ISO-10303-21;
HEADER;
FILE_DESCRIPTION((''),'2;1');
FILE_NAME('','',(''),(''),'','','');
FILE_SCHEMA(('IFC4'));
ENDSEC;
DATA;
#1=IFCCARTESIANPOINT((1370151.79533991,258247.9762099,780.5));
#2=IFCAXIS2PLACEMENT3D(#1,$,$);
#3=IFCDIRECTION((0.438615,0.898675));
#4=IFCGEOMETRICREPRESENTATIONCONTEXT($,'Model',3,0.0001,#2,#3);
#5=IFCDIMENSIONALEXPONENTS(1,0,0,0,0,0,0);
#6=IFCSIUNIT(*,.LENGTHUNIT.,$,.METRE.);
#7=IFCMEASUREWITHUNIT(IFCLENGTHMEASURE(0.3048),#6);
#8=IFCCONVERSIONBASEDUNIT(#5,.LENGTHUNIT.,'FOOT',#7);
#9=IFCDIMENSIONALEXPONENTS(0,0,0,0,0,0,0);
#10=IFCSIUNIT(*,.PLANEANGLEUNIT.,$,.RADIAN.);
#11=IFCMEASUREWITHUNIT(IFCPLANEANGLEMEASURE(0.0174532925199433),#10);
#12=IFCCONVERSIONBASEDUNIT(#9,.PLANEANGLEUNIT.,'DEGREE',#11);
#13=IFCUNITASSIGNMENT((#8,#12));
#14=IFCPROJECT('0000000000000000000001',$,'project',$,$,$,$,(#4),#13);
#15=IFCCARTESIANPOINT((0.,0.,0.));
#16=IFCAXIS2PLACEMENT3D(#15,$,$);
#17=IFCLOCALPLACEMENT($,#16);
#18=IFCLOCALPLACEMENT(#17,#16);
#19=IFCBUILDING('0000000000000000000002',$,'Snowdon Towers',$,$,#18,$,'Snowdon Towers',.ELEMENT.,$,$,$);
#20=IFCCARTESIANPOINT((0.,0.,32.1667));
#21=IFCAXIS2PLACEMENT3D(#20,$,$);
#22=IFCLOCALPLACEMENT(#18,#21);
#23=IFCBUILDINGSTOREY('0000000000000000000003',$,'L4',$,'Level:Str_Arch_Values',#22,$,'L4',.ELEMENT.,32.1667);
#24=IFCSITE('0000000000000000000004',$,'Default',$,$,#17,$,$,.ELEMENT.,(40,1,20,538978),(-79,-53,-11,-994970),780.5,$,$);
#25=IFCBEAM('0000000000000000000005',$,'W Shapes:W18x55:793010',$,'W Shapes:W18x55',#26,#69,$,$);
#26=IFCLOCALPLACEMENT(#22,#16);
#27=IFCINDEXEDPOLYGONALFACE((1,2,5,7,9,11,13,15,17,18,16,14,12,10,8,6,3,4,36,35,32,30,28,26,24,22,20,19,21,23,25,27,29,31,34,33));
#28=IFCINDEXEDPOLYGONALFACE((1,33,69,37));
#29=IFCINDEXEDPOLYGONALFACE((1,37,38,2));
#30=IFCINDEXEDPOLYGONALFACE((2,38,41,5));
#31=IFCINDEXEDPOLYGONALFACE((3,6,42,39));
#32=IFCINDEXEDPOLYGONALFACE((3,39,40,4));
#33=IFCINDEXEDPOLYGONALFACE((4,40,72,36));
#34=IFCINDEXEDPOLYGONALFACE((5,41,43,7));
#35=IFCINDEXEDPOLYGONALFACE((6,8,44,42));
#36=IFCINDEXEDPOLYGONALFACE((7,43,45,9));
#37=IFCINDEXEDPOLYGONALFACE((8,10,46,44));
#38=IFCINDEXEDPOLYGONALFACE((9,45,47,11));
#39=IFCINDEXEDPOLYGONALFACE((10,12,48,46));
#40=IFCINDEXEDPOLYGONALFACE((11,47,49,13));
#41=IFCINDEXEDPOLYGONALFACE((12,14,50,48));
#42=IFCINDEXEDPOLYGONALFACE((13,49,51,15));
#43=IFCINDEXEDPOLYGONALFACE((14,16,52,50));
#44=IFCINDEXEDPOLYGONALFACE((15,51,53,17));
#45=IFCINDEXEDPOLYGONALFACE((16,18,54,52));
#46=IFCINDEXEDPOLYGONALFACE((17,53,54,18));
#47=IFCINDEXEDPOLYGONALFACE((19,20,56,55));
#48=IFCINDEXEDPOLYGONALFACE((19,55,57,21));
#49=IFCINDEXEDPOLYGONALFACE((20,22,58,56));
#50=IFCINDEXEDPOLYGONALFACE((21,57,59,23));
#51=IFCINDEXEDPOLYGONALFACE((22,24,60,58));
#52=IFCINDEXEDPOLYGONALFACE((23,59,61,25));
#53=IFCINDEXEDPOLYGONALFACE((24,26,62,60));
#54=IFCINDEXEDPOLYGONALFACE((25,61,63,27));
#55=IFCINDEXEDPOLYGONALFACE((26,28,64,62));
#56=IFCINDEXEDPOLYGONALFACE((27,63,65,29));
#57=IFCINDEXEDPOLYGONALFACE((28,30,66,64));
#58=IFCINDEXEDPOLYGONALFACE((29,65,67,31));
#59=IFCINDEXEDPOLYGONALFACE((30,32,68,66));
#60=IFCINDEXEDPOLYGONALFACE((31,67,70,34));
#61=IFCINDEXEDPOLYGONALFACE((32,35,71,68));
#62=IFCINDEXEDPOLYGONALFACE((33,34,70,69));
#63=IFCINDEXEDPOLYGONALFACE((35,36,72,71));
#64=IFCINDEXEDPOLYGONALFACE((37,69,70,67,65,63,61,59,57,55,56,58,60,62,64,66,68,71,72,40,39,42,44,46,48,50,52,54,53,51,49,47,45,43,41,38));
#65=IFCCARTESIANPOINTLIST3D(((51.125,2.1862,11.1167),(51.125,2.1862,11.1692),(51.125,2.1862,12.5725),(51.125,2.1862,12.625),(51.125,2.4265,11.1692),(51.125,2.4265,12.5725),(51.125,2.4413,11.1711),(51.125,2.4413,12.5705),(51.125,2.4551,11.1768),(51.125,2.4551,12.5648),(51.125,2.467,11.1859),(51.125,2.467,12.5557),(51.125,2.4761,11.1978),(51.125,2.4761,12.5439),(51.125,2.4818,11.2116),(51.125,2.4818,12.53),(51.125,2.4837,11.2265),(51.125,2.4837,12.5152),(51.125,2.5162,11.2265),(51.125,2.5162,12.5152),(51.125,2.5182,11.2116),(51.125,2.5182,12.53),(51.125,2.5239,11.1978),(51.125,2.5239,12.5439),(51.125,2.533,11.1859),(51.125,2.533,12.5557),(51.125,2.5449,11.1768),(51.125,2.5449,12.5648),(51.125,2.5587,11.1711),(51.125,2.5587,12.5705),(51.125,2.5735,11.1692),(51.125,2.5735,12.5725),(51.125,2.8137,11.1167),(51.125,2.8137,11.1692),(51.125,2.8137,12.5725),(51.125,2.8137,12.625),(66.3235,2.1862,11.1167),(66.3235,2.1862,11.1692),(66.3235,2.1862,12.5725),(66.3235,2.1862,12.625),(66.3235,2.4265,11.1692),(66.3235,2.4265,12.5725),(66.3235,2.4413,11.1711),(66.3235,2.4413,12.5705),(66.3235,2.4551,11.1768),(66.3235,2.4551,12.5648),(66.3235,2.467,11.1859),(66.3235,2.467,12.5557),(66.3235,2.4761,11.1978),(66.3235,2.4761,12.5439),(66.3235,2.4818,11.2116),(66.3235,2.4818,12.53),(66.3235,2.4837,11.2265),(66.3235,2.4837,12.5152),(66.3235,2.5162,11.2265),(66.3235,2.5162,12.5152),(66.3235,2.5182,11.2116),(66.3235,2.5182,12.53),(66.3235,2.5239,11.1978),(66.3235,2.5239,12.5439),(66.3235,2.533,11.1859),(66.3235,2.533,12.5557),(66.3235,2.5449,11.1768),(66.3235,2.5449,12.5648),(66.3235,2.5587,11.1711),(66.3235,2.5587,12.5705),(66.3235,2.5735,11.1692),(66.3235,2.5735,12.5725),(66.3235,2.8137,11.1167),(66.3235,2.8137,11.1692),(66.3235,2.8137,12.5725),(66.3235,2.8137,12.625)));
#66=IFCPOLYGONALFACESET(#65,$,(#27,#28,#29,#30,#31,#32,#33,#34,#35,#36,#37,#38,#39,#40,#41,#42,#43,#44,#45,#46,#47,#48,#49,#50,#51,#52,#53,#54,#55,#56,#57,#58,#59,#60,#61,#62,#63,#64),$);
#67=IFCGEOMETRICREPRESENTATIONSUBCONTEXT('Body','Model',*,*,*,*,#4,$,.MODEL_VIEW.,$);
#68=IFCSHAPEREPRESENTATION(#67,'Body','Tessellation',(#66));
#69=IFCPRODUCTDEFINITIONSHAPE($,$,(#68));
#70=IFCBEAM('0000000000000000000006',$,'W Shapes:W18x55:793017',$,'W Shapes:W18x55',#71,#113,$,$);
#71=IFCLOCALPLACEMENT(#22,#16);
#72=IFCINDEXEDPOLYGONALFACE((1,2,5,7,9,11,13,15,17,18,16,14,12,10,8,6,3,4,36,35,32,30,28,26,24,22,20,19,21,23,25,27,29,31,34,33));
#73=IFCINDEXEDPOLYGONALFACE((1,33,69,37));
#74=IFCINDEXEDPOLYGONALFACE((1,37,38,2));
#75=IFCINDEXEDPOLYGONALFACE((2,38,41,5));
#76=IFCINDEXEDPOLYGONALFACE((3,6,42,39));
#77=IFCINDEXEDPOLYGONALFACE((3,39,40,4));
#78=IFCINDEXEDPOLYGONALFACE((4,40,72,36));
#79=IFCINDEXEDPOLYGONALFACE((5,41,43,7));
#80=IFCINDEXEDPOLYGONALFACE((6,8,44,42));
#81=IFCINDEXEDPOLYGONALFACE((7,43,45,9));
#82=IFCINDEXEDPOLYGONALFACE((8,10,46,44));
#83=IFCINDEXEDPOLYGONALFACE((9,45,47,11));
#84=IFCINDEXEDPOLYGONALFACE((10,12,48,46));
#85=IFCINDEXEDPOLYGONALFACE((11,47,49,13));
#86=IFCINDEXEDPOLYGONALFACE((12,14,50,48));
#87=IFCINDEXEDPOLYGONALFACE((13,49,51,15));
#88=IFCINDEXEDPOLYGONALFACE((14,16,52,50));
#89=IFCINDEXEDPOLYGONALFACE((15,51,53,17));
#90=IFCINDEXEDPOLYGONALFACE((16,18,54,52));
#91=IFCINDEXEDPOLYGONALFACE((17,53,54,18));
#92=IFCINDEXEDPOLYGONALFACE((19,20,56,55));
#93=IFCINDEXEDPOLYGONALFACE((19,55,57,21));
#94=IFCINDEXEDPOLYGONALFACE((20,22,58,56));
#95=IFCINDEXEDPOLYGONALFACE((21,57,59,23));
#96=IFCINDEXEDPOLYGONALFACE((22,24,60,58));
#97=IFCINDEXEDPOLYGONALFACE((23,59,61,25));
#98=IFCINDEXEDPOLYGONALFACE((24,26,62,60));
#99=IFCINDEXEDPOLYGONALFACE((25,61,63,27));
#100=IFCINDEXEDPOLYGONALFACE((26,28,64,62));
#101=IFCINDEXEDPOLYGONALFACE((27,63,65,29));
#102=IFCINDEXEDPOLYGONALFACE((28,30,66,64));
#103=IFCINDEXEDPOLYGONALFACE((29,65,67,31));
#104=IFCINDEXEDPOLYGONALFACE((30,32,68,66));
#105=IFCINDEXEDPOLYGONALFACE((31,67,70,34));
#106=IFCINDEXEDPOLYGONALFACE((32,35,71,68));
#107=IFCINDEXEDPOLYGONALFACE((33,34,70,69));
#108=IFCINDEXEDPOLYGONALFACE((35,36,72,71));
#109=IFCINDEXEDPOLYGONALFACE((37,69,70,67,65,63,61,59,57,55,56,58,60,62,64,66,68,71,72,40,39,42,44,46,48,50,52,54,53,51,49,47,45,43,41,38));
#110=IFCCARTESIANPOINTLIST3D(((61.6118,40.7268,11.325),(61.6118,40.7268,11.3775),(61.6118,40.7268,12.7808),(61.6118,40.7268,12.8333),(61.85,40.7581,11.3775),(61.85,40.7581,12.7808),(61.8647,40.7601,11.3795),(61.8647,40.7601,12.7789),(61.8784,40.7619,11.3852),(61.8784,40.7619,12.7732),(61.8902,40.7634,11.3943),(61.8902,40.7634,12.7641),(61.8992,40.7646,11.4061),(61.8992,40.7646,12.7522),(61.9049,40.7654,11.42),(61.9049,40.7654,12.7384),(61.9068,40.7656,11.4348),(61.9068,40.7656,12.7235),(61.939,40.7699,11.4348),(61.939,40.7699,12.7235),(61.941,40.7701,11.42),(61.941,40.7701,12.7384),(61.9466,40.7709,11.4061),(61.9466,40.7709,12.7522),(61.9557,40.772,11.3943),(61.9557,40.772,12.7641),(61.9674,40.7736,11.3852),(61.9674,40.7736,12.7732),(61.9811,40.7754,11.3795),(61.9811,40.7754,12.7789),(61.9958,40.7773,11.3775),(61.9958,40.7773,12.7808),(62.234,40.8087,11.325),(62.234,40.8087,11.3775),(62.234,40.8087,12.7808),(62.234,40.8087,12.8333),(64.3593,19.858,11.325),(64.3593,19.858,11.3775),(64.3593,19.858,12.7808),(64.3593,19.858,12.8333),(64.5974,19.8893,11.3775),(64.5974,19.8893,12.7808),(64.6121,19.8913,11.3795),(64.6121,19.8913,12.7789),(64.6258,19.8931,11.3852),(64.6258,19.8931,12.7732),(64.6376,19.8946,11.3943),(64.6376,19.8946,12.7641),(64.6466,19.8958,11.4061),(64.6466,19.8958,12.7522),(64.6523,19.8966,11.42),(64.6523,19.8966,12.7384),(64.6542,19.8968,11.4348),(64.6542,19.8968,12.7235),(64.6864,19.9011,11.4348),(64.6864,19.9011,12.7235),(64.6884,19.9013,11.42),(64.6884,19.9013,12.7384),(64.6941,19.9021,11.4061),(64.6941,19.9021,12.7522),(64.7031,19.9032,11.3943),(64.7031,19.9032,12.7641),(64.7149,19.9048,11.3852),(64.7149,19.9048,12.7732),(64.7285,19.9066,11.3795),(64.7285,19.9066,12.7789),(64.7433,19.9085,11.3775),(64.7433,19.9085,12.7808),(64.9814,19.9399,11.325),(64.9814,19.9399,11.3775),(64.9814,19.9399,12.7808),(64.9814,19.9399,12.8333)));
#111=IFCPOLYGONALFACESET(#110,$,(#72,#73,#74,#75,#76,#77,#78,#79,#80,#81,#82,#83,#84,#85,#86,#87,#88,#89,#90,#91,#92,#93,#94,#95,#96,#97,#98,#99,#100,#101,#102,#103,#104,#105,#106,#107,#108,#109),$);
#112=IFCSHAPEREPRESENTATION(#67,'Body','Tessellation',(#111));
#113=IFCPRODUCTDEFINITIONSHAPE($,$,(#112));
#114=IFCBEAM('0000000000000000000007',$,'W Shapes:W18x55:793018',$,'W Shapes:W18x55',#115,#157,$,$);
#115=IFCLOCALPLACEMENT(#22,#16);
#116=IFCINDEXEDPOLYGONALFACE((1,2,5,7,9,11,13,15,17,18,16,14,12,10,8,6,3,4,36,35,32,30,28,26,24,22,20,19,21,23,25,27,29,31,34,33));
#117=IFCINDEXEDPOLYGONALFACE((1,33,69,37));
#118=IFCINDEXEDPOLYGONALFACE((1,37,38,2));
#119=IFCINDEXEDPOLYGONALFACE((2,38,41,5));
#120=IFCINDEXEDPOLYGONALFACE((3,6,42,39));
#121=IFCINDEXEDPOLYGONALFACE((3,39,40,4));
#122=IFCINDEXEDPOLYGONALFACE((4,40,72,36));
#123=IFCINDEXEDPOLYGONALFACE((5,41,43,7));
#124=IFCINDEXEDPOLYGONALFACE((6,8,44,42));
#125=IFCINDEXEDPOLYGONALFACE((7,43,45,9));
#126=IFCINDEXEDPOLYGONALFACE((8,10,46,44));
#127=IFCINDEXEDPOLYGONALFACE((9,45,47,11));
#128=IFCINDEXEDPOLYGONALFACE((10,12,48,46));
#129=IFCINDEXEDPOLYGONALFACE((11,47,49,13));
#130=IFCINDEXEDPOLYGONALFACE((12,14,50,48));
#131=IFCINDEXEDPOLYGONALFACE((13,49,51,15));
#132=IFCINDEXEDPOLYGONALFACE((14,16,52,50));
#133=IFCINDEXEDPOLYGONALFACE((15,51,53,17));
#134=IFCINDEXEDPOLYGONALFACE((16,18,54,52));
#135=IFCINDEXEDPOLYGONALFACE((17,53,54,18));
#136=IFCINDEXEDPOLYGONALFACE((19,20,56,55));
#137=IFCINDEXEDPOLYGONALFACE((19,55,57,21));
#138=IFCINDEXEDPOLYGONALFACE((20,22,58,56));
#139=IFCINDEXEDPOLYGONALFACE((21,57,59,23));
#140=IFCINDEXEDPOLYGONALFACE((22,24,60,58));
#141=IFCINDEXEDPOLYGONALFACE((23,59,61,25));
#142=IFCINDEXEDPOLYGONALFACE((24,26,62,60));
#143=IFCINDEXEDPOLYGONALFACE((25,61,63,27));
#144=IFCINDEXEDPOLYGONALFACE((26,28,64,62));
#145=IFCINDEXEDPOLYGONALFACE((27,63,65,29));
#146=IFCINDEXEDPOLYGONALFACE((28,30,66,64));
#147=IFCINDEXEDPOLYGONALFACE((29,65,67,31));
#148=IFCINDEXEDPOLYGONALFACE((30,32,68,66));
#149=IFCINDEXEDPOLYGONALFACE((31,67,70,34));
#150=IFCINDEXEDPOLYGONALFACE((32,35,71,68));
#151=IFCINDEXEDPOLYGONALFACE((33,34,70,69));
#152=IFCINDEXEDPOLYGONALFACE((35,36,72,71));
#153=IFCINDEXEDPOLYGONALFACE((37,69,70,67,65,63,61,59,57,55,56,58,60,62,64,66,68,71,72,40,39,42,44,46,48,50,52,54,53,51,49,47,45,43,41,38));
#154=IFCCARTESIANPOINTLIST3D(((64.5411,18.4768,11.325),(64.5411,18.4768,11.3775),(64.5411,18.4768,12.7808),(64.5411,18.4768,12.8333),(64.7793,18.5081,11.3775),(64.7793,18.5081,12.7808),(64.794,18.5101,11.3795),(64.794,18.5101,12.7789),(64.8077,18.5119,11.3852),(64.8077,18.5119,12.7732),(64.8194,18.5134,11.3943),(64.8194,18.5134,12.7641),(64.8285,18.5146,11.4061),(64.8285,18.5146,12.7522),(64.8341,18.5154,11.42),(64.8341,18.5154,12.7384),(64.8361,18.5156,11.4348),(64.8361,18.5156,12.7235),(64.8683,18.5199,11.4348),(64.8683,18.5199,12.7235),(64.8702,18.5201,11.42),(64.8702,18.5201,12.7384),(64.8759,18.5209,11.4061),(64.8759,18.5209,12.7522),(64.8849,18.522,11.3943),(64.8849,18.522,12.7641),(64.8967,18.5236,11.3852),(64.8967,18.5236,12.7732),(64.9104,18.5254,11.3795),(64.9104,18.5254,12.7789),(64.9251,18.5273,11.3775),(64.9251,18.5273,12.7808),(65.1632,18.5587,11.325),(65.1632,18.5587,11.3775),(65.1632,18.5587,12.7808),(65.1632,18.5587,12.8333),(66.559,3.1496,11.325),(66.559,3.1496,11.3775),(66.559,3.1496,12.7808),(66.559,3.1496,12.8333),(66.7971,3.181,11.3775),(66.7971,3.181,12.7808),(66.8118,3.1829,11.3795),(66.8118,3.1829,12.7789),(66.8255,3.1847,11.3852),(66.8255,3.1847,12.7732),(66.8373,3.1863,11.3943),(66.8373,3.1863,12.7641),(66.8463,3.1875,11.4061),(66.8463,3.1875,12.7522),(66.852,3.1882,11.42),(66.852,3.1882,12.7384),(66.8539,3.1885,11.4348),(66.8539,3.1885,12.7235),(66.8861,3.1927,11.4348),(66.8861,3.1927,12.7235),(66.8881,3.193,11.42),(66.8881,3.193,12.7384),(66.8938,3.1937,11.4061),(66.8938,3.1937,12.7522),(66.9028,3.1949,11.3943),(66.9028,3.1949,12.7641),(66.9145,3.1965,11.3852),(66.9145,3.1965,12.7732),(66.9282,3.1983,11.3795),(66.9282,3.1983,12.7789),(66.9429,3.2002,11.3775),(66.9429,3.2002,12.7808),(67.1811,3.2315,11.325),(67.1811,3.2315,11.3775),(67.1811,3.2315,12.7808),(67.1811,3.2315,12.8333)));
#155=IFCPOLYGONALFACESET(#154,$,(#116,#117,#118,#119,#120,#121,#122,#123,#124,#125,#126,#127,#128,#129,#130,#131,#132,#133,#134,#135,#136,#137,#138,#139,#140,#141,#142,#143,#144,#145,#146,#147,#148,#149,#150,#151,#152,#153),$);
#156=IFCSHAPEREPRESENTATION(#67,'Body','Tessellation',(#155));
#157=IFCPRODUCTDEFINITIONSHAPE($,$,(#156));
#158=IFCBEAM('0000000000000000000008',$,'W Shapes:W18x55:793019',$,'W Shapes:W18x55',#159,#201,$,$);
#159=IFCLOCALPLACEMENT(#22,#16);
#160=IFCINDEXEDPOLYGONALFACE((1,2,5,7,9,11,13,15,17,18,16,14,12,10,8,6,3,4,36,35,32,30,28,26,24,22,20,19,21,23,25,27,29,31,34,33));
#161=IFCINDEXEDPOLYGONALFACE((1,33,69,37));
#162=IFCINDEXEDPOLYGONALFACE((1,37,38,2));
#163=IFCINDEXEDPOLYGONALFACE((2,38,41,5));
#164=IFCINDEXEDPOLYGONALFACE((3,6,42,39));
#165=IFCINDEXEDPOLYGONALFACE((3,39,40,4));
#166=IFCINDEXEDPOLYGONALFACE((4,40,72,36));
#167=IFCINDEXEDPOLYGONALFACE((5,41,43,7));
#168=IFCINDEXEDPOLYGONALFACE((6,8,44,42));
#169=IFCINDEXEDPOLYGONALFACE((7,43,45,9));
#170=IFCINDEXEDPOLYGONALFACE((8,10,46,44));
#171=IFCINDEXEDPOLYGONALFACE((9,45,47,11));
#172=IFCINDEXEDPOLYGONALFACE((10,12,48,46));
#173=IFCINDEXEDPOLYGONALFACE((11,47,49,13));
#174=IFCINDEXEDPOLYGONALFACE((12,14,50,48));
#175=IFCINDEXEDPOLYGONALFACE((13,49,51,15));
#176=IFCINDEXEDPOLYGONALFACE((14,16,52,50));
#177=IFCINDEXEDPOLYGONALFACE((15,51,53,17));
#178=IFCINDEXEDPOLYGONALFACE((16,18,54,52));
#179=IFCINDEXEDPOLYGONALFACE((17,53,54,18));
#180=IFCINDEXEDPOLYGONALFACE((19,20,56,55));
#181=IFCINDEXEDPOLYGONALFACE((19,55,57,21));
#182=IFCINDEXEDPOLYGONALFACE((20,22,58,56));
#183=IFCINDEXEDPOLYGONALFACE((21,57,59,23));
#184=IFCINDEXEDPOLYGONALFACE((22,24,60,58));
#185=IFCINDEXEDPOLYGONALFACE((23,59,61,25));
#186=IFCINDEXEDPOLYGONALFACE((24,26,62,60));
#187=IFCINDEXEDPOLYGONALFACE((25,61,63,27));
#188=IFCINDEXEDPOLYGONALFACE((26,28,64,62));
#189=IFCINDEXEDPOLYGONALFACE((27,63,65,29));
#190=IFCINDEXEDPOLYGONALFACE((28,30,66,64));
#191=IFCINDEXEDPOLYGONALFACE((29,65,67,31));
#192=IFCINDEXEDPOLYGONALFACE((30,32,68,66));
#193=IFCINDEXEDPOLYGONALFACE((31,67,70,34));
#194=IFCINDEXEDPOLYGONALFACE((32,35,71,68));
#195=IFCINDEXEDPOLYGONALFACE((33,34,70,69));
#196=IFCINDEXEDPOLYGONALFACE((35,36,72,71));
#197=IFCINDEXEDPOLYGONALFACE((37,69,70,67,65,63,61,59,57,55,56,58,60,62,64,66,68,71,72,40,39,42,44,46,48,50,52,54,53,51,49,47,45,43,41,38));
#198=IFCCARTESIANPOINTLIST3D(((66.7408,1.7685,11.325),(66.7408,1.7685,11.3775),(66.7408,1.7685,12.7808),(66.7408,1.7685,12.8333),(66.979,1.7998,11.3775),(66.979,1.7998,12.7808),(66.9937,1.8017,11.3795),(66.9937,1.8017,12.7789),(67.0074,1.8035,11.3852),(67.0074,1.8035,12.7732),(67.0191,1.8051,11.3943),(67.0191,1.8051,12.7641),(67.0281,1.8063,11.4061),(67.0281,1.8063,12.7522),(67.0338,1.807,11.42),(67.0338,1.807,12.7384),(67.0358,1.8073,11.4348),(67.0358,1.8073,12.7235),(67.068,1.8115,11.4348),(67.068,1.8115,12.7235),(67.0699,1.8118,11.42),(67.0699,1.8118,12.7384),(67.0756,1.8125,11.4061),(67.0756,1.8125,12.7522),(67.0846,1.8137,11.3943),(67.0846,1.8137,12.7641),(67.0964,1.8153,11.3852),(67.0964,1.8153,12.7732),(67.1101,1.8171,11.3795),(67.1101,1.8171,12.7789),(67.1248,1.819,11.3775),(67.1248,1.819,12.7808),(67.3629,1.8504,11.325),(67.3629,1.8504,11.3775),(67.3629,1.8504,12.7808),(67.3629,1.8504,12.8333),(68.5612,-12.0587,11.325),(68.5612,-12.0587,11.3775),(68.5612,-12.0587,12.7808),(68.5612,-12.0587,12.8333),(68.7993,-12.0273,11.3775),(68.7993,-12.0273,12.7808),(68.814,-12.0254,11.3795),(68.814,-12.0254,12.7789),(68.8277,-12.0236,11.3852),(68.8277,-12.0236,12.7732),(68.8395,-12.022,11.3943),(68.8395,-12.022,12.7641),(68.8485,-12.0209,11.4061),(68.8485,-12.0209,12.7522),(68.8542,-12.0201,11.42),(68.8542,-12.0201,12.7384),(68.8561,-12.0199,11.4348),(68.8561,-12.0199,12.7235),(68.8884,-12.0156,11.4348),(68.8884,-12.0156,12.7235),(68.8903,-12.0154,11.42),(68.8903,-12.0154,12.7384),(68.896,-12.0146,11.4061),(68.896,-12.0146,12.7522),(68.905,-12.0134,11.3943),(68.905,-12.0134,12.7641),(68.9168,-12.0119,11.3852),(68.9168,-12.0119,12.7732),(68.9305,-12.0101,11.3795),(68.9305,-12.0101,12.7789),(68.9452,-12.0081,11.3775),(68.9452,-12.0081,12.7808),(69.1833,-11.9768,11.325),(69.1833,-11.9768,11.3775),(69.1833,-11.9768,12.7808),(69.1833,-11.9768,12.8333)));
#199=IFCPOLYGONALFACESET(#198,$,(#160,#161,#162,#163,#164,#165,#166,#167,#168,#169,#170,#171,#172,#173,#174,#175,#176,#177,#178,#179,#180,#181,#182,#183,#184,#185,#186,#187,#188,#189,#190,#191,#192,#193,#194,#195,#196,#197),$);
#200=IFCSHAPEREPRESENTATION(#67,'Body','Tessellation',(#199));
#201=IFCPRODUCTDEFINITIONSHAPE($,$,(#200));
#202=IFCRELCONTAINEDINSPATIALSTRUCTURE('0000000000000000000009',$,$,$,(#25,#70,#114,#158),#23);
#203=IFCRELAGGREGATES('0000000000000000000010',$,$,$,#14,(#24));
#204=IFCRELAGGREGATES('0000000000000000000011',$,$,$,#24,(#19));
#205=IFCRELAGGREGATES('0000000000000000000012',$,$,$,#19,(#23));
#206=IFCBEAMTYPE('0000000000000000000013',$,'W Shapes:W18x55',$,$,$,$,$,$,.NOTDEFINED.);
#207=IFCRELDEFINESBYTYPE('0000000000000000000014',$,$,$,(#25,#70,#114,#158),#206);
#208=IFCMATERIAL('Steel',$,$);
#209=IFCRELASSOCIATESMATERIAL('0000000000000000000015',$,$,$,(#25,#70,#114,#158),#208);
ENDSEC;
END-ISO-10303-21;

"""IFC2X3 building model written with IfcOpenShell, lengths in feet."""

from ifc_helpers import new_model, entity, si_unit, converted_unit, direction, frame, frame_2d, origin, place, context, subcontext, project, spatial, i_section, extrude, material, type_object, element, save


model = new_model("IFC2X3")

# Units and contexts
model_context = context("Model", 3, precision=0.0001, world=frame((1370151.79533991, 258247.9762099, 780.5)), true_north=direction((0.438615, 0.898675)))
body_context = subcontext(model_context, "Body", "Model", "MODEL_VIEW")
ifc_project = project(units=[converted_unit("LENGTHUNIT", "FOOT", entity("IfcLengthMeasure", 0.3048), si_unit("LENGTHUNIT", "METRE"), dimensions=[1, 0, 0, 0, 0, 0, 0]), converted_unit("PLANEANGLEUNIT", "DEGREE", entity("IfcPlaneAngleMeasure", 0.0174532925199433), si_unit("PLANEANGLEUNIT", "RADIAN"), dimensions=[0, 0, 0, 0, 0, 0, 0])], contexts=[model_context])

# Site, building, storey
site_placement = place(None, origin())
site = spatial("IfcSite", under=ifc_project, at=site_placement, Name="Default", CompositionType="ELEMENT", RefLatitude=(40, 1, 20, 538978), RefLongitude=(-79, -53, -11, -994970), RefElevation=780.5)
building_placement = place(site_placement, origin())
building = spatial("IfcBuilding", under=site, at=building_placement, Name="Snowdon Towers", LongName="Snowdon Towers", CompositionType="ELEMENT")
storey_placement = place(building_placement, frame((0.0, 0.0, 32.1667)))
storey = spatial("IfcBuildingStorey", under=building, at=storey_placement, Name="L4", ObjectType="Level:Str_Arch_Values", LongName="L4", CompositionType="ELEMENT", Elevation=32.1667)

# Beams
ifc_material = material(Name="Steel")
beam_type_1 = type_object("IfcBeamType", Name="W Shapes:W18x55", PredefinedType="NOTDEFINED")
beam_1_placement = place(storey_placement, frame((51.125, 2.5, 12.8333)))
element("IfcBeam", 1, at=beam_1_placement, inside=storey, type_object=beam_type_1, material=ifc_material, Name="W Shapes:W18x55:793010", ObjectType="W Shapes:W18x55", context=body_context, shape_type="SweptSolid", body=[
    extrude(i_section(OverallWidth=0.6275, OverallDepth=1.5083, WebThickness=0.0325, FlangeThickness=0.0525, FilletRadius=0.0573, at=frame_2d((0.0, 0.0), x_axis=(0.0, 1.0))), frame((0.0, 0.0, -0.9625), z_axis=(1.0, 0.0, 0.0), x_axis=(0.0, 0.0, -1.0)), (0.0, 0.0, 1.0), 15.1985),
])
beam_2_placement = place(storey_placement, frame((61.8201, 41.5489, 12.8333), z_axis=(0.0, 0.0, 1.0), x_axis=(0.130526, -0.991445, 0.0)))
element("IfcBeam", 2, at=beam_2_placement, inside=storey, type_object=beam_type_1, material=ifc_material, Name="W Shapes:W18x55:793017", ObjectType="W Shapes:W18x55", context=body_context, shape_type="SweptSolid", body=[
    extrude(i_section(OverallWidth=0.6275, OverallDepth=1.5083, WebThickness=0.0325, FlangeThickness=0.0525, FilletRadius=0.0573, at=frame_2d((0.0, 0.0), x_axis=(0.0, 1.0))), frame((0.7879, 0.0, -0.7542), z_axis=(1.0, 0.0, 0.0), x_axis=(0.0, 0.0, -1.0)), (0.0, 0.0, 1.0), 21.0489),
])
beam_3_placement = place(storey_placement, frame((64.7713, 19.1322, 12.8333), z_axis=(0.0, 0.0, 1.0), x_axis=(0.130526, -0.991445, 0.0)))
element("IfcBeam", 3, at=beam_3_placement, inside=storey, type_object=beam_type_1, material=ifc_material, Name="W Shapes:W18x55:793018", ObjectType="W Shapes:W18x55", context=body_context, shape_type="SweptSolid", body=[
    extrude(i_section(OverallWidth=0.6275, OverallDepth=1.5083, WebThickness=0.0325, FlangeThickness=0.0525, FilletRadius=0.0573, at=frame_2d((0.0, 0.0), x_axis=(0.0, 1.0))), frame((0.6198, 0.0, -0.7542), z_axis=(1.0, 0.0, 0.0), x_axis=(0.0, 0.0, -1.0)), (0.0, 0.0, 1.0), 15.4594),
])
beam_4_placement = place(storey_placement, frame((66.971, 2.4239, 12.8333), z_axis=(0.0, 0.0, 1.0), x_axis=(0.130526, -0.991445, 0.0)))
element("IfcBeam", 4, at=beam_4_placement, inside=storey, type_object=beam_type_1, material=ifc_material, Name="W Shapes:W18x55:793019", ObjectType="W Shapes:W18x55", context=body_context, shape_type="SweptSolid", body=[
    extrude(i_section(OverallWidth=0.6275, OverallDepth=1.5083, WebThickness=0.0325, FlangeThickness=0.0525, FilletRadius=0.0573, at=frame_2d((0.0, 0.0), x_axis=(0.0, 1.0))), frame((0.6198, 0.0, -0.7542), z_axis=(1.0, 0.0, 0.0), x_axis=(0.0, 0.0, -1.0)), (0.0, 0.0, 1.0), 13.9465),
])

save(model, "model.ifc")
